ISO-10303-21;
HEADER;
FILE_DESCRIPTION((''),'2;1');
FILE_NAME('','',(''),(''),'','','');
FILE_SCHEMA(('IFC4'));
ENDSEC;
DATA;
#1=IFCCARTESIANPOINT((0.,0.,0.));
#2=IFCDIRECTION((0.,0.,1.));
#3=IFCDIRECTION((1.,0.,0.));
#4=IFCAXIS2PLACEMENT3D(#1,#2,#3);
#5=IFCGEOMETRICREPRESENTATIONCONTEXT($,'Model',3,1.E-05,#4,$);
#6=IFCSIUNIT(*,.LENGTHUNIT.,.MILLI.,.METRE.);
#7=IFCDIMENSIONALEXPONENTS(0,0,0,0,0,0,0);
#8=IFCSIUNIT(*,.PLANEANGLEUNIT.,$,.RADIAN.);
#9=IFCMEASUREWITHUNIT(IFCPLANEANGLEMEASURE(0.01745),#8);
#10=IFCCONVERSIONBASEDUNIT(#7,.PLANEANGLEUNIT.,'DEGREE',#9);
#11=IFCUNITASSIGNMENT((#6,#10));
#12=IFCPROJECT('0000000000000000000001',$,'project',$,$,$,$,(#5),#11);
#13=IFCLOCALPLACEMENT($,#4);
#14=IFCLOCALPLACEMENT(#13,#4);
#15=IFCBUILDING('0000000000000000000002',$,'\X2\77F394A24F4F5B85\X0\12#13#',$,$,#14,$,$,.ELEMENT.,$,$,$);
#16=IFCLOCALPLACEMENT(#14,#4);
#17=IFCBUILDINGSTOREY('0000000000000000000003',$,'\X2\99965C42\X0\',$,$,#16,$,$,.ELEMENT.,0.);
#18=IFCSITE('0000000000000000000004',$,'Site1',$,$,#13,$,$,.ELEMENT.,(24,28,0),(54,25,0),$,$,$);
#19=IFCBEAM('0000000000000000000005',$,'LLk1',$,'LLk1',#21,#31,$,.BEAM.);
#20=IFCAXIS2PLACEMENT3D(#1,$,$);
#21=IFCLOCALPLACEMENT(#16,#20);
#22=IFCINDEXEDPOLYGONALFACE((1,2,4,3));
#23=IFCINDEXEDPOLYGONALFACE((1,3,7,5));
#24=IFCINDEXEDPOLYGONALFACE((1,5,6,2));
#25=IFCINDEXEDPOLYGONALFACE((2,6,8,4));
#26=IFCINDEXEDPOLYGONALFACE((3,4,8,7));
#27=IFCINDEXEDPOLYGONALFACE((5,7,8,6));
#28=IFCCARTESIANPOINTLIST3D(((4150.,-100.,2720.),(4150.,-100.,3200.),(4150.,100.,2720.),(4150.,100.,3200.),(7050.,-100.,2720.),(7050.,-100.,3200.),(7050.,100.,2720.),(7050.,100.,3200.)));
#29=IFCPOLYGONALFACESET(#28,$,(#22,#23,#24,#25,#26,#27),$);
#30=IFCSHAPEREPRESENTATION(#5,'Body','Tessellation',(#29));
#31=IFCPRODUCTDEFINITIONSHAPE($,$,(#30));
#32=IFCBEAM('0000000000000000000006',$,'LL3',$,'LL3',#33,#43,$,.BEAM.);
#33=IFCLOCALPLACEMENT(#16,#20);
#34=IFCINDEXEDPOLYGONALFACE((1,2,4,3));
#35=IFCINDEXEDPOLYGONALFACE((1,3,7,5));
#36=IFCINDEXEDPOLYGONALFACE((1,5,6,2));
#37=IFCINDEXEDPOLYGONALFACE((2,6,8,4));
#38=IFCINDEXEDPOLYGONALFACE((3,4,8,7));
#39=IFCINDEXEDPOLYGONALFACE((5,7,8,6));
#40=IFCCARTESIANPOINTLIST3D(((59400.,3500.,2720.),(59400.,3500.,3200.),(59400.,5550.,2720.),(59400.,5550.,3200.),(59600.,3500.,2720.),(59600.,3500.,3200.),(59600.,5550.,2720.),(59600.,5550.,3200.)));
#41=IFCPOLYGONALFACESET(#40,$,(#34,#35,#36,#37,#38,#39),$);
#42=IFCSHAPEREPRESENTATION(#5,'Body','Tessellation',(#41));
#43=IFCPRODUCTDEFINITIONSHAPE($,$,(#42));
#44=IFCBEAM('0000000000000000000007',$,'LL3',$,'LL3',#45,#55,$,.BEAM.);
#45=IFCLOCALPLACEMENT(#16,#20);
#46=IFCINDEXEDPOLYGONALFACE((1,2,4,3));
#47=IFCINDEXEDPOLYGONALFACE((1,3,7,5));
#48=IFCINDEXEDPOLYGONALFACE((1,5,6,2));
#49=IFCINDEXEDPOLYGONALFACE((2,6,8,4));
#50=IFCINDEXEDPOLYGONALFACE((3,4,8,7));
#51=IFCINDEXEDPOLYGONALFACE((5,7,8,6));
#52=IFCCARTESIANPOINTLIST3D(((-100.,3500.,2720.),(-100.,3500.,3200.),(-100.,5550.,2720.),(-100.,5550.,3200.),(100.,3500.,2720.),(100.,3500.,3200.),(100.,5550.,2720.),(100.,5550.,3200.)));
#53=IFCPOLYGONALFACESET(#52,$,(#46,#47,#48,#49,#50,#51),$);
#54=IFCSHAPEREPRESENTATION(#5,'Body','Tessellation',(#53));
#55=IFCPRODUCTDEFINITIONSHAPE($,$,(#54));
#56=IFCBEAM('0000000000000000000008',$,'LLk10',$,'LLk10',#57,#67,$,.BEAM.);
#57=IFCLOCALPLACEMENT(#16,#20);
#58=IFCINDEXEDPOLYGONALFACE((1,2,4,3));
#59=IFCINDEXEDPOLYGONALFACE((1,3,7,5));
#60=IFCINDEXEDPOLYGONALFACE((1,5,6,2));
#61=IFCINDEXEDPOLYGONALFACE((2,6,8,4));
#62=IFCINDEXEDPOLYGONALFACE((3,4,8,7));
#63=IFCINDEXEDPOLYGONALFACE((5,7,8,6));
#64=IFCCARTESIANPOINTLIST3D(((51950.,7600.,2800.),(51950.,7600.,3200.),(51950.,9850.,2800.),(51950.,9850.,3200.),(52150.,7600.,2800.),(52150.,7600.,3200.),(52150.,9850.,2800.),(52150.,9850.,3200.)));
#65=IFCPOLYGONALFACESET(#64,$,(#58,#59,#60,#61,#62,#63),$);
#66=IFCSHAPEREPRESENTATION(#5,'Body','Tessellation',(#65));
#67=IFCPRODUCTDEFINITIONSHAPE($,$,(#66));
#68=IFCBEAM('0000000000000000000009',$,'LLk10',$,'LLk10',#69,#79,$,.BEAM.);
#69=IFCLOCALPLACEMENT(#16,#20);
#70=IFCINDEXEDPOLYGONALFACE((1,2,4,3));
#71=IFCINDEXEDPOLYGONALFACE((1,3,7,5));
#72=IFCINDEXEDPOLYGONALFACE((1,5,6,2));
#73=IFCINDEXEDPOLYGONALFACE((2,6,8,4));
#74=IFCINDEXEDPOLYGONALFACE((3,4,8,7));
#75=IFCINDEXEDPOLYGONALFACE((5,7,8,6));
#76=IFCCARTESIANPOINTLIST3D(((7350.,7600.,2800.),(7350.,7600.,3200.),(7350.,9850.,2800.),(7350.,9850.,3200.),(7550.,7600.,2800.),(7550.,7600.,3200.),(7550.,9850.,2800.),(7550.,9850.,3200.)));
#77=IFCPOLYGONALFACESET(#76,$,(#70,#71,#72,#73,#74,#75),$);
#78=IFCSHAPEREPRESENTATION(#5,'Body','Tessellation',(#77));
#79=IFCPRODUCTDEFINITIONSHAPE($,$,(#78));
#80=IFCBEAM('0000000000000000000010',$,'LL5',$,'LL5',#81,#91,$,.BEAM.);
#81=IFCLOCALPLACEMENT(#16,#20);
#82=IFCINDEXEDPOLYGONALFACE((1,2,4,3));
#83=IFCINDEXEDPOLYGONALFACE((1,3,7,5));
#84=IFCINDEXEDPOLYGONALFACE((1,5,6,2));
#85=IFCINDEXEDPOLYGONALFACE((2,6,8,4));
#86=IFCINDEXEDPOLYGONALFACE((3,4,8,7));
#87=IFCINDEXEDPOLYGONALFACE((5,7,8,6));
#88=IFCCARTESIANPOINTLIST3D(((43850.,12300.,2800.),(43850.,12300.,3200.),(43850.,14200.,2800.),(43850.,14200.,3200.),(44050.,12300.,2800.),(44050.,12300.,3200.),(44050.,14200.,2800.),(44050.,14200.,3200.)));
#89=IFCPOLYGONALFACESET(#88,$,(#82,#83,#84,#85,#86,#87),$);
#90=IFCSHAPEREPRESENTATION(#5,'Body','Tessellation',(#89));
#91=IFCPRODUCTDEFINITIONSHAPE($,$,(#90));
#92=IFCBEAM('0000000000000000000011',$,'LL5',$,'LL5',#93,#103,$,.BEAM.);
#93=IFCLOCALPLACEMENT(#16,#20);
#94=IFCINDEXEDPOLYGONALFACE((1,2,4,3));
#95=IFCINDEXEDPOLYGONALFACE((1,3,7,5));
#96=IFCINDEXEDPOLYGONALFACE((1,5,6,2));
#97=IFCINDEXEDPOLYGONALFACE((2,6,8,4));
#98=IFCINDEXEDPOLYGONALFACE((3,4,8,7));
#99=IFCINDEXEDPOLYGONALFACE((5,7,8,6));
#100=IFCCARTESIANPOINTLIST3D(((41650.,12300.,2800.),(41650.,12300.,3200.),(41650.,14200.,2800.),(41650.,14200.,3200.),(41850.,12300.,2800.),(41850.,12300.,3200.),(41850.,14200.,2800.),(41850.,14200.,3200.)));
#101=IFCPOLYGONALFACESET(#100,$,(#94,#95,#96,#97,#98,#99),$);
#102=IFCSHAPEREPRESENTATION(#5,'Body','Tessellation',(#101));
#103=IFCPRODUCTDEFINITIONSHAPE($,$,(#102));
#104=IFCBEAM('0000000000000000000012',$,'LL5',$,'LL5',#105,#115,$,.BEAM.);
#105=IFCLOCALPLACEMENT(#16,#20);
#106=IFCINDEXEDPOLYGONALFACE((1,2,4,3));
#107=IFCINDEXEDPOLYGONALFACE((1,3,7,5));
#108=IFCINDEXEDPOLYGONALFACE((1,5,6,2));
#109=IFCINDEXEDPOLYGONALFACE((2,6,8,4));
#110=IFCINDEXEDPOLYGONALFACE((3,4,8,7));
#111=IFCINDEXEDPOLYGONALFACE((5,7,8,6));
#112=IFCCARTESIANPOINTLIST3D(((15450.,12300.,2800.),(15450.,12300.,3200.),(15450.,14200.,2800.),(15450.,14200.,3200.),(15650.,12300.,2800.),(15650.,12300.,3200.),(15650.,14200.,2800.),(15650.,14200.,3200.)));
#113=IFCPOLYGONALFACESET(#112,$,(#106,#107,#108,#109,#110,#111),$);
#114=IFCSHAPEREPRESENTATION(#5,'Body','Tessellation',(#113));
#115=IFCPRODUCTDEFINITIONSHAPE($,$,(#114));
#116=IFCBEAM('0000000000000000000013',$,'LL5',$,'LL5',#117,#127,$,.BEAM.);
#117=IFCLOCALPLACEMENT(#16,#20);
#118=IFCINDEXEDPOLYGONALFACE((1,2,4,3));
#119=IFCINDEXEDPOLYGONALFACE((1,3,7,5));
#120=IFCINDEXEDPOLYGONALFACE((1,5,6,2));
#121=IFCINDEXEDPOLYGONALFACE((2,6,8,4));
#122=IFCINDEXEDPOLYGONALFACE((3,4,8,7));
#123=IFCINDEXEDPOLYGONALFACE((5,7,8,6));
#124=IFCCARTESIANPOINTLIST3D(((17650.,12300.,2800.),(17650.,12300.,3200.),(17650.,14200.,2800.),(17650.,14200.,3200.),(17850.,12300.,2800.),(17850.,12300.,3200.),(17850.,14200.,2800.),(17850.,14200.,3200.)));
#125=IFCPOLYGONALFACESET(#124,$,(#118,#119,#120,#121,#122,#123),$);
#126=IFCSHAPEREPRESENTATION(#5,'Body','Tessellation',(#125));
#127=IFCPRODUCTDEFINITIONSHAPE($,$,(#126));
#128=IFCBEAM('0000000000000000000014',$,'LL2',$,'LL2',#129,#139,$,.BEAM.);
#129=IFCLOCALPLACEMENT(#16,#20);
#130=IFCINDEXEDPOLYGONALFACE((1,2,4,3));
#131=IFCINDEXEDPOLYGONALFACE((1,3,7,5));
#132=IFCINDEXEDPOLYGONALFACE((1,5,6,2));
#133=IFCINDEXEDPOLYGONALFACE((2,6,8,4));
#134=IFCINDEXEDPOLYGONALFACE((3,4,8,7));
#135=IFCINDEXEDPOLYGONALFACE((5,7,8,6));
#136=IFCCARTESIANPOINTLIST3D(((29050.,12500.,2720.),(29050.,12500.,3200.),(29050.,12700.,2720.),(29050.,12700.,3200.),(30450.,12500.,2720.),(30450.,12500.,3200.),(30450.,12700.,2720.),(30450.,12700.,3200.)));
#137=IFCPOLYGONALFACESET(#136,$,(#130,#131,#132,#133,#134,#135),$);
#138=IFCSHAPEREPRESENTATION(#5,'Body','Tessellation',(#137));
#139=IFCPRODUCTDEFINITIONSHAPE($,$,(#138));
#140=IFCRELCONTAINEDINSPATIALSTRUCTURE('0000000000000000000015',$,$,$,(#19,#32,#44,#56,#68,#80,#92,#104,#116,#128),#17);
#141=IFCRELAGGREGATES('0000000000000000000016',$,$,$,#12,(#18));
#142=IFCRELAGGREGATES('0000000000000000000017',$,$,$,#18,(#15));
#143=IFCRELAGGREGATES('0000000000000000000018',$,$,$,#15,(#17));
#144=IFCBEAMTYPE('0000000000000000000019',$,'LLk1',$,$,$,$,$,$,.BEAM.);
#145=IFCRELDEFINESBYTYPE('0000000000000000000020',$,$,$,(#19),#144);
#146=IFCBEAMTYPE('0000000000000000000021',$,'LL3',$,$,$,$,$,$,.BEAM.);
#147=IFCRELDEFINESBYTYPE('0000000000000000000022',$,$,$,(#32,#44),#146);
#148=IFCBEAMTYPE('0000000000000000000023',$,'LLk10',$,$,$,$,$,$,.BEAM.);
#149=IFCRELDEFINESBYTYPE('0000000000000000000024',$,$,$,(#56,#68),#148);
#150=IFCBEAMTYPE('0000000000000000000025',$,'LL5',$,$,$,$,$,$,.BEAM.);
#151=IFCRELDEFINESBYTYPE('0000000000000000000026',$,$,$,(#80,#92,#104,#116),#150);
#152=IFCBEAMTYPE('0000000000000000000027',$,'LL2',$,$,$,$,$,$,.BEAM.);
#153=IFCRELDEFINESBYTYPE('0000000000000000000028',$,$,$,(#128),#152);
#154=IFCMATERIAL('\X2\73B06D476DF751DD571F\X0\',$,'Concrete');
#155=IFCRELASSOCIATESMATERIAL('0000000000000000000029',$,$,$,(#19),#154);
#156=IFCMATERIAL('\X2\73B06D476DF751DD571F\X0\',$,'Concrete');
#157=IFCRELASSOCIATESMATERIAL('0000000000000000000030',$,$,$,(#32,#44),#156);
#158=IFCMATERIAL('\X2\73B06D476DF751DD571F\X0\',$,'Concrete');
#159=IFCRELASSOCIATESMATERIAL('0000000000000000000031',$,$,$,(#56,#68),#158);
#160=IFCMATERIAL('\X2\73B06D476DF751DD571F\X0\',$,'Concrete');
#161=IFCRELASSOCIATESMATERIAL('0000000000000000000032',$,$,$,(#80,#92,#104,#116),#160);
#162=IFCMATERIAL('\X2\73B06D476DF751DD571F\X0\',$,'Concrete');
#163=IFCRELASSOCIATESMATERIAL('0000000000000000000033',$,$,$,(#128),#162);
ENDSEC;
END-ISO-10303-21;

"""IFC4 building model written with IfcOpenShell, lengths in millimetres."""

from ifc_helpers import new_model, entity, si_unit, converted_unit, frame, origin_with_axes, place, context, project, spatial, polyline, outline, extrude, material, type_object, element, save


model = new_model("IFC4")

# Units and contexts
model_context = context("Model", 3, precision=1e-05, world=origin_with_axes())
ifc_project = project(units=[si_unit("LENGTHUNIT", "METRE", prefix="MILLI"), converted_unit("PLANEANGLEUNIT", "DEGREE", entity("IfcPlaneAngleMeasure", 0.01745), si_unit("PLANEANGLEUNIT", "RADIAN"), dimensions=[0, 0, 0, 0, 0, 0, 0])], contexts=[model_context])

# Site, building, storey
site_placement = place(None, origin_with_axes())
site = spatial("IfcSite", under=ifc_project, at=site_placement, Name="Site1", CompositionType="ELEMENT", RefLatitude=(24, 28, 0), RefLongitude=(54, 25, 0))
building_placement = place(site_placement, origin_with_axes())
building = spatial("IfcBuilding", under=site, at=building_placement, Name="石钢住宅12#13#", CompositionType="ELEMENT")
storey_placement = place(building_placement, origin_with_axes())
storey = spatial("IfcBuildingStorey", under=building, at=storey_placement, Name="首层", CompositionType="ELEMENT", Elevation=0.0)

# Beams
ifc_material_1 = material(Name="现浇混凝土", Category="Concrete")
beam_type_1 = type_object("IfcBeamType", Name="LLk1", PredefinedType="BEAM")
beam_1_placement = place(storey_placement, origin_with_axes())
element("IfcBeam", 1, at=beam_1_placement, inside=storey, type_object=beam_type_1, material=ifc_material_1, Name="LLk1", ObjectType="LLk1", PredefinedType="BEAM", context=model_context, shape_type="SweptSolid", body=[
    extrude(outline(polyline([(0.0, 0.0), (480.0, 0.0), (480.0, 200.0), (0.0, 200.0), (0.0, 0.0)])), frame((4150.0, 100.0, 2720.0), z_axis=(1.0, 0.0, 0.0), x_axis=(0.0, 0.0, 1.0)), (0.0, 0.0, 1.0), 2900.0),
])
ifc_material_2 = material(Name="现浇混凝土", Category="Concrete")
beam_type_2 = type_object("IfcBeamType", Name="LL3", PredefinedType="BEAM")
beam_2_placement = place(storey_placement, origin_with_axes())
element("IfcBeam", 2, at=beam_2_placement, inside=storey, type_object=beam_type_2, material=ifc_material_2, Name="LL3", ObjectType="LL3", PredefinedType="BEAM", context=model_context, shape_type="SweptSolid", body=[
    extrude(outline(polyline([(0.0, 0.0), (200.0, 0.0), (200.0, 480.0), (0.0, 480.0), (0.0, 0.0)])), frame((59600.0, 3500.0, 2720.0), z_axis=(0.0, 1.0, 0.0), x_axis=(-1.0, 0.0, 0.0)), (0.0, 0.0, 1.0), 2050.0),
])
beam_3_placement = place(storey_placement, origin_with_axes())
element("IfcBeam", 3, at=beam_3_placement, inside=storey, type_object=beam_type_2, material=ifc_material_2, Name="LL3", ObjectType="LL3", PredefinedType="BEAM", context=model_context, shape_type="SweptSolid", body=[
    extrude(outline(polyline([(0.0, 0.0), (480.0, 0.0), (480.0, 200.0), (0.0, 200.0), (0.0, 0.0)])), frame((-100.0, 3500.0, 2720.0), z_axis=(0.0, 1.0, 0.0), x_axis=(0.0, 0.0, 1.0)), (0.0, 0.0, 1.0), 2050.0),
])
ifc_material_3 = material(Name="现浇混凝土", Category="Concrete")
beam_type_3 = type_object("IfcBeamType", Name="LLk10", PredefinedType="BEAM")
beam_4_placement = place(storey_placement, origin_with_axes())
element("IfcBeam", 4, at=beam_4_placement, inside=storey, type_object=beam_type_3, material=ifc_material_3, Name="LLk10", ObjectType="LLk10", PredefinedType="BEAM", context=model_context, shape_type="SweptSolid", body=[
    extrude(outline(polyline([(0.0, 0.0), (200.0, 0.0), (200.0, 400.0), (0.0, 400.0), (0.0, 0.0)])), frame((52150.0, 7600.0, 2800.0), z_axis=(0.0, 1.0, 0.0), x_axis=(-1.0, 0.0, 0.0)), (0.0, 0.0, 1.0), 2250.0),
])
beam_5_placement = place(storey_placement, origin_with_axes())
element("IfcBeam", 5, at=beam_5_placement, inside=storey, type_object=beam_type_3, material=ifc_material_3, Name="LLk10", ObjectType="LLk10", PredefinedType="BEAM", context=model_context, shape_type="SweptSolid", body=[
    extrude(outline(polyline([(0.0, 0.0), (400.0, 0.0), (400.0, 200.0), (0.0, 200.0), (0.0, 0.0)])), frame((7350.0, 7600.0, 2800.0), z_axis=(0.0, 1.0, 0.0), x_axis=(0.0, 0.0, 1.0)), (0.0, 0.0, 1.0), 2250.0),
])
ifc_material_4 = material(Name="现浇混凝土", Category="Concrete")
beam_type_4 = type_object("IfcBeamType", Name="LL5", PredefinedType="BEAM")
beam_6_placement = place(storey_placement, origin_with_axes())
element("IfcBeam", 6, at=beam_6_placement, inside=storey, type_object=beam_type_4, material=ifc_material_4, Name="LL5", ObjectType="LL5", PredefinedType="BEAM", context=model_context, shape_type="SweptSolid", body=[
    extrude(outline(polyline([(0.0, 0.0), (200.0, 0.0), (200.0, 400.0), (0.0, 400.0), (0.0, 0.0)])), frame((44050.0, 12300.0, 2800.0), z_axis=(0.0, 1.0, 0.0), x_axis=(-1.0, 0.0, 0.0)), (0.0, 0.0, 1.0), 1900.0),
])
beam_7_placement = place(storey_placement, origin_with_axes())
element("IfcBeam", 7, at=beam_7_placement, inside=storey, type_object=beam_type_4, material=ifc_material_4, Name="LL5", ObjectType="LL5", PredefinedType="BEAM", context=model_context, shape_type="SweptSolid", body=[
    extrude(outline(polyline([(0.0, 0.0), (200.0, 0.0), (200.0, 400.0), (0.0, 400.0), (0.0, 0.0)])), frame((41850.0, 12300.0, 2800.0), z_axis=(0.0, 1.0, 0.0), x_axis=(-1.0, 0.0, 0.0)), (0.0, 0.0, 1.0), 1900.0),
])
beam_8_placement = place(storey_placement, origin_with_axes())
element("IfcBeam", 8, at=beam_8_placement, inside=storey, type_object=beam_type_4, material=ifc_material_4, Name="LL5", ObjectType="LL5", PredefinedType="BEAM", context=model_context, shape_type="SweptSolid", body=[
    extrude(outline(polyline([(0.0, 0.0), (400.0, 0.0), (400.0, 200.0), (0.0, 200.0), (0.0, 0.0)])), frame((15450.0, 12300.0, 2800.0), z_axis=(0.0, 1.0, 0.0), x_axis=(0.0, 0.0, 1.0)), (0.0, 0.0, 1.0), 1900.0),
])
beam_9_placement = place(storey_placement, origin_with_axes())
element("IfcBeam", 9, at=beam_9_placement, inside=storey, type_object=beam_type_4, material=ifc_material_4, Name="LL5", ObjectType="LL5", PredefinedType="BEAM", context=model_context, shape_type="SweptSolid", body=[
    extrude(outline(polyline([(0.0, 0.0), (400.0, 0.0), (400.0, 200.0), (0.0, 200.0), (0.0, 0.0)])), frame((17650.0, 12300.0, 2800.0), z_axis=(0.0, 1.0, 0.0), x_axis=(0.0, 0.0, 1.0)), (0.0, 0.0, 1.0), 1900.0),
])
ifc_material_5 = material(Name="现浇混凝土", Category="Concrete")
beam_type_5 = type_object("IfcBeamType", Name="LL2", PredefinedType="BEAM")
beam_10_placement = place(storey_placement, origin_with_axes())
element("IfcBeam", 10, at=beam_10_placement, inside=storey, type_object=beam_type_5, material=ifc_material_5, Name="LL2", ObjectType="LL2", PredefinedType="BEAM", context=model_context, shape_type="SweptSolid", body=[
    extrude(outline(polyline([(0.0, 0.0), (480.0, 0.0), (480.0, 200.0), (0.0, 200.0), (0.0, 0.0)])), frame((29050.0, 12700.0, 2720.0), z_axis=(1.0, 0.0, 0.0), x_axis=(0.0, 0.0, 1.0)), (0.0, 0.0, 1.0), 1400.0),
])

save(model, "model.ifc")
